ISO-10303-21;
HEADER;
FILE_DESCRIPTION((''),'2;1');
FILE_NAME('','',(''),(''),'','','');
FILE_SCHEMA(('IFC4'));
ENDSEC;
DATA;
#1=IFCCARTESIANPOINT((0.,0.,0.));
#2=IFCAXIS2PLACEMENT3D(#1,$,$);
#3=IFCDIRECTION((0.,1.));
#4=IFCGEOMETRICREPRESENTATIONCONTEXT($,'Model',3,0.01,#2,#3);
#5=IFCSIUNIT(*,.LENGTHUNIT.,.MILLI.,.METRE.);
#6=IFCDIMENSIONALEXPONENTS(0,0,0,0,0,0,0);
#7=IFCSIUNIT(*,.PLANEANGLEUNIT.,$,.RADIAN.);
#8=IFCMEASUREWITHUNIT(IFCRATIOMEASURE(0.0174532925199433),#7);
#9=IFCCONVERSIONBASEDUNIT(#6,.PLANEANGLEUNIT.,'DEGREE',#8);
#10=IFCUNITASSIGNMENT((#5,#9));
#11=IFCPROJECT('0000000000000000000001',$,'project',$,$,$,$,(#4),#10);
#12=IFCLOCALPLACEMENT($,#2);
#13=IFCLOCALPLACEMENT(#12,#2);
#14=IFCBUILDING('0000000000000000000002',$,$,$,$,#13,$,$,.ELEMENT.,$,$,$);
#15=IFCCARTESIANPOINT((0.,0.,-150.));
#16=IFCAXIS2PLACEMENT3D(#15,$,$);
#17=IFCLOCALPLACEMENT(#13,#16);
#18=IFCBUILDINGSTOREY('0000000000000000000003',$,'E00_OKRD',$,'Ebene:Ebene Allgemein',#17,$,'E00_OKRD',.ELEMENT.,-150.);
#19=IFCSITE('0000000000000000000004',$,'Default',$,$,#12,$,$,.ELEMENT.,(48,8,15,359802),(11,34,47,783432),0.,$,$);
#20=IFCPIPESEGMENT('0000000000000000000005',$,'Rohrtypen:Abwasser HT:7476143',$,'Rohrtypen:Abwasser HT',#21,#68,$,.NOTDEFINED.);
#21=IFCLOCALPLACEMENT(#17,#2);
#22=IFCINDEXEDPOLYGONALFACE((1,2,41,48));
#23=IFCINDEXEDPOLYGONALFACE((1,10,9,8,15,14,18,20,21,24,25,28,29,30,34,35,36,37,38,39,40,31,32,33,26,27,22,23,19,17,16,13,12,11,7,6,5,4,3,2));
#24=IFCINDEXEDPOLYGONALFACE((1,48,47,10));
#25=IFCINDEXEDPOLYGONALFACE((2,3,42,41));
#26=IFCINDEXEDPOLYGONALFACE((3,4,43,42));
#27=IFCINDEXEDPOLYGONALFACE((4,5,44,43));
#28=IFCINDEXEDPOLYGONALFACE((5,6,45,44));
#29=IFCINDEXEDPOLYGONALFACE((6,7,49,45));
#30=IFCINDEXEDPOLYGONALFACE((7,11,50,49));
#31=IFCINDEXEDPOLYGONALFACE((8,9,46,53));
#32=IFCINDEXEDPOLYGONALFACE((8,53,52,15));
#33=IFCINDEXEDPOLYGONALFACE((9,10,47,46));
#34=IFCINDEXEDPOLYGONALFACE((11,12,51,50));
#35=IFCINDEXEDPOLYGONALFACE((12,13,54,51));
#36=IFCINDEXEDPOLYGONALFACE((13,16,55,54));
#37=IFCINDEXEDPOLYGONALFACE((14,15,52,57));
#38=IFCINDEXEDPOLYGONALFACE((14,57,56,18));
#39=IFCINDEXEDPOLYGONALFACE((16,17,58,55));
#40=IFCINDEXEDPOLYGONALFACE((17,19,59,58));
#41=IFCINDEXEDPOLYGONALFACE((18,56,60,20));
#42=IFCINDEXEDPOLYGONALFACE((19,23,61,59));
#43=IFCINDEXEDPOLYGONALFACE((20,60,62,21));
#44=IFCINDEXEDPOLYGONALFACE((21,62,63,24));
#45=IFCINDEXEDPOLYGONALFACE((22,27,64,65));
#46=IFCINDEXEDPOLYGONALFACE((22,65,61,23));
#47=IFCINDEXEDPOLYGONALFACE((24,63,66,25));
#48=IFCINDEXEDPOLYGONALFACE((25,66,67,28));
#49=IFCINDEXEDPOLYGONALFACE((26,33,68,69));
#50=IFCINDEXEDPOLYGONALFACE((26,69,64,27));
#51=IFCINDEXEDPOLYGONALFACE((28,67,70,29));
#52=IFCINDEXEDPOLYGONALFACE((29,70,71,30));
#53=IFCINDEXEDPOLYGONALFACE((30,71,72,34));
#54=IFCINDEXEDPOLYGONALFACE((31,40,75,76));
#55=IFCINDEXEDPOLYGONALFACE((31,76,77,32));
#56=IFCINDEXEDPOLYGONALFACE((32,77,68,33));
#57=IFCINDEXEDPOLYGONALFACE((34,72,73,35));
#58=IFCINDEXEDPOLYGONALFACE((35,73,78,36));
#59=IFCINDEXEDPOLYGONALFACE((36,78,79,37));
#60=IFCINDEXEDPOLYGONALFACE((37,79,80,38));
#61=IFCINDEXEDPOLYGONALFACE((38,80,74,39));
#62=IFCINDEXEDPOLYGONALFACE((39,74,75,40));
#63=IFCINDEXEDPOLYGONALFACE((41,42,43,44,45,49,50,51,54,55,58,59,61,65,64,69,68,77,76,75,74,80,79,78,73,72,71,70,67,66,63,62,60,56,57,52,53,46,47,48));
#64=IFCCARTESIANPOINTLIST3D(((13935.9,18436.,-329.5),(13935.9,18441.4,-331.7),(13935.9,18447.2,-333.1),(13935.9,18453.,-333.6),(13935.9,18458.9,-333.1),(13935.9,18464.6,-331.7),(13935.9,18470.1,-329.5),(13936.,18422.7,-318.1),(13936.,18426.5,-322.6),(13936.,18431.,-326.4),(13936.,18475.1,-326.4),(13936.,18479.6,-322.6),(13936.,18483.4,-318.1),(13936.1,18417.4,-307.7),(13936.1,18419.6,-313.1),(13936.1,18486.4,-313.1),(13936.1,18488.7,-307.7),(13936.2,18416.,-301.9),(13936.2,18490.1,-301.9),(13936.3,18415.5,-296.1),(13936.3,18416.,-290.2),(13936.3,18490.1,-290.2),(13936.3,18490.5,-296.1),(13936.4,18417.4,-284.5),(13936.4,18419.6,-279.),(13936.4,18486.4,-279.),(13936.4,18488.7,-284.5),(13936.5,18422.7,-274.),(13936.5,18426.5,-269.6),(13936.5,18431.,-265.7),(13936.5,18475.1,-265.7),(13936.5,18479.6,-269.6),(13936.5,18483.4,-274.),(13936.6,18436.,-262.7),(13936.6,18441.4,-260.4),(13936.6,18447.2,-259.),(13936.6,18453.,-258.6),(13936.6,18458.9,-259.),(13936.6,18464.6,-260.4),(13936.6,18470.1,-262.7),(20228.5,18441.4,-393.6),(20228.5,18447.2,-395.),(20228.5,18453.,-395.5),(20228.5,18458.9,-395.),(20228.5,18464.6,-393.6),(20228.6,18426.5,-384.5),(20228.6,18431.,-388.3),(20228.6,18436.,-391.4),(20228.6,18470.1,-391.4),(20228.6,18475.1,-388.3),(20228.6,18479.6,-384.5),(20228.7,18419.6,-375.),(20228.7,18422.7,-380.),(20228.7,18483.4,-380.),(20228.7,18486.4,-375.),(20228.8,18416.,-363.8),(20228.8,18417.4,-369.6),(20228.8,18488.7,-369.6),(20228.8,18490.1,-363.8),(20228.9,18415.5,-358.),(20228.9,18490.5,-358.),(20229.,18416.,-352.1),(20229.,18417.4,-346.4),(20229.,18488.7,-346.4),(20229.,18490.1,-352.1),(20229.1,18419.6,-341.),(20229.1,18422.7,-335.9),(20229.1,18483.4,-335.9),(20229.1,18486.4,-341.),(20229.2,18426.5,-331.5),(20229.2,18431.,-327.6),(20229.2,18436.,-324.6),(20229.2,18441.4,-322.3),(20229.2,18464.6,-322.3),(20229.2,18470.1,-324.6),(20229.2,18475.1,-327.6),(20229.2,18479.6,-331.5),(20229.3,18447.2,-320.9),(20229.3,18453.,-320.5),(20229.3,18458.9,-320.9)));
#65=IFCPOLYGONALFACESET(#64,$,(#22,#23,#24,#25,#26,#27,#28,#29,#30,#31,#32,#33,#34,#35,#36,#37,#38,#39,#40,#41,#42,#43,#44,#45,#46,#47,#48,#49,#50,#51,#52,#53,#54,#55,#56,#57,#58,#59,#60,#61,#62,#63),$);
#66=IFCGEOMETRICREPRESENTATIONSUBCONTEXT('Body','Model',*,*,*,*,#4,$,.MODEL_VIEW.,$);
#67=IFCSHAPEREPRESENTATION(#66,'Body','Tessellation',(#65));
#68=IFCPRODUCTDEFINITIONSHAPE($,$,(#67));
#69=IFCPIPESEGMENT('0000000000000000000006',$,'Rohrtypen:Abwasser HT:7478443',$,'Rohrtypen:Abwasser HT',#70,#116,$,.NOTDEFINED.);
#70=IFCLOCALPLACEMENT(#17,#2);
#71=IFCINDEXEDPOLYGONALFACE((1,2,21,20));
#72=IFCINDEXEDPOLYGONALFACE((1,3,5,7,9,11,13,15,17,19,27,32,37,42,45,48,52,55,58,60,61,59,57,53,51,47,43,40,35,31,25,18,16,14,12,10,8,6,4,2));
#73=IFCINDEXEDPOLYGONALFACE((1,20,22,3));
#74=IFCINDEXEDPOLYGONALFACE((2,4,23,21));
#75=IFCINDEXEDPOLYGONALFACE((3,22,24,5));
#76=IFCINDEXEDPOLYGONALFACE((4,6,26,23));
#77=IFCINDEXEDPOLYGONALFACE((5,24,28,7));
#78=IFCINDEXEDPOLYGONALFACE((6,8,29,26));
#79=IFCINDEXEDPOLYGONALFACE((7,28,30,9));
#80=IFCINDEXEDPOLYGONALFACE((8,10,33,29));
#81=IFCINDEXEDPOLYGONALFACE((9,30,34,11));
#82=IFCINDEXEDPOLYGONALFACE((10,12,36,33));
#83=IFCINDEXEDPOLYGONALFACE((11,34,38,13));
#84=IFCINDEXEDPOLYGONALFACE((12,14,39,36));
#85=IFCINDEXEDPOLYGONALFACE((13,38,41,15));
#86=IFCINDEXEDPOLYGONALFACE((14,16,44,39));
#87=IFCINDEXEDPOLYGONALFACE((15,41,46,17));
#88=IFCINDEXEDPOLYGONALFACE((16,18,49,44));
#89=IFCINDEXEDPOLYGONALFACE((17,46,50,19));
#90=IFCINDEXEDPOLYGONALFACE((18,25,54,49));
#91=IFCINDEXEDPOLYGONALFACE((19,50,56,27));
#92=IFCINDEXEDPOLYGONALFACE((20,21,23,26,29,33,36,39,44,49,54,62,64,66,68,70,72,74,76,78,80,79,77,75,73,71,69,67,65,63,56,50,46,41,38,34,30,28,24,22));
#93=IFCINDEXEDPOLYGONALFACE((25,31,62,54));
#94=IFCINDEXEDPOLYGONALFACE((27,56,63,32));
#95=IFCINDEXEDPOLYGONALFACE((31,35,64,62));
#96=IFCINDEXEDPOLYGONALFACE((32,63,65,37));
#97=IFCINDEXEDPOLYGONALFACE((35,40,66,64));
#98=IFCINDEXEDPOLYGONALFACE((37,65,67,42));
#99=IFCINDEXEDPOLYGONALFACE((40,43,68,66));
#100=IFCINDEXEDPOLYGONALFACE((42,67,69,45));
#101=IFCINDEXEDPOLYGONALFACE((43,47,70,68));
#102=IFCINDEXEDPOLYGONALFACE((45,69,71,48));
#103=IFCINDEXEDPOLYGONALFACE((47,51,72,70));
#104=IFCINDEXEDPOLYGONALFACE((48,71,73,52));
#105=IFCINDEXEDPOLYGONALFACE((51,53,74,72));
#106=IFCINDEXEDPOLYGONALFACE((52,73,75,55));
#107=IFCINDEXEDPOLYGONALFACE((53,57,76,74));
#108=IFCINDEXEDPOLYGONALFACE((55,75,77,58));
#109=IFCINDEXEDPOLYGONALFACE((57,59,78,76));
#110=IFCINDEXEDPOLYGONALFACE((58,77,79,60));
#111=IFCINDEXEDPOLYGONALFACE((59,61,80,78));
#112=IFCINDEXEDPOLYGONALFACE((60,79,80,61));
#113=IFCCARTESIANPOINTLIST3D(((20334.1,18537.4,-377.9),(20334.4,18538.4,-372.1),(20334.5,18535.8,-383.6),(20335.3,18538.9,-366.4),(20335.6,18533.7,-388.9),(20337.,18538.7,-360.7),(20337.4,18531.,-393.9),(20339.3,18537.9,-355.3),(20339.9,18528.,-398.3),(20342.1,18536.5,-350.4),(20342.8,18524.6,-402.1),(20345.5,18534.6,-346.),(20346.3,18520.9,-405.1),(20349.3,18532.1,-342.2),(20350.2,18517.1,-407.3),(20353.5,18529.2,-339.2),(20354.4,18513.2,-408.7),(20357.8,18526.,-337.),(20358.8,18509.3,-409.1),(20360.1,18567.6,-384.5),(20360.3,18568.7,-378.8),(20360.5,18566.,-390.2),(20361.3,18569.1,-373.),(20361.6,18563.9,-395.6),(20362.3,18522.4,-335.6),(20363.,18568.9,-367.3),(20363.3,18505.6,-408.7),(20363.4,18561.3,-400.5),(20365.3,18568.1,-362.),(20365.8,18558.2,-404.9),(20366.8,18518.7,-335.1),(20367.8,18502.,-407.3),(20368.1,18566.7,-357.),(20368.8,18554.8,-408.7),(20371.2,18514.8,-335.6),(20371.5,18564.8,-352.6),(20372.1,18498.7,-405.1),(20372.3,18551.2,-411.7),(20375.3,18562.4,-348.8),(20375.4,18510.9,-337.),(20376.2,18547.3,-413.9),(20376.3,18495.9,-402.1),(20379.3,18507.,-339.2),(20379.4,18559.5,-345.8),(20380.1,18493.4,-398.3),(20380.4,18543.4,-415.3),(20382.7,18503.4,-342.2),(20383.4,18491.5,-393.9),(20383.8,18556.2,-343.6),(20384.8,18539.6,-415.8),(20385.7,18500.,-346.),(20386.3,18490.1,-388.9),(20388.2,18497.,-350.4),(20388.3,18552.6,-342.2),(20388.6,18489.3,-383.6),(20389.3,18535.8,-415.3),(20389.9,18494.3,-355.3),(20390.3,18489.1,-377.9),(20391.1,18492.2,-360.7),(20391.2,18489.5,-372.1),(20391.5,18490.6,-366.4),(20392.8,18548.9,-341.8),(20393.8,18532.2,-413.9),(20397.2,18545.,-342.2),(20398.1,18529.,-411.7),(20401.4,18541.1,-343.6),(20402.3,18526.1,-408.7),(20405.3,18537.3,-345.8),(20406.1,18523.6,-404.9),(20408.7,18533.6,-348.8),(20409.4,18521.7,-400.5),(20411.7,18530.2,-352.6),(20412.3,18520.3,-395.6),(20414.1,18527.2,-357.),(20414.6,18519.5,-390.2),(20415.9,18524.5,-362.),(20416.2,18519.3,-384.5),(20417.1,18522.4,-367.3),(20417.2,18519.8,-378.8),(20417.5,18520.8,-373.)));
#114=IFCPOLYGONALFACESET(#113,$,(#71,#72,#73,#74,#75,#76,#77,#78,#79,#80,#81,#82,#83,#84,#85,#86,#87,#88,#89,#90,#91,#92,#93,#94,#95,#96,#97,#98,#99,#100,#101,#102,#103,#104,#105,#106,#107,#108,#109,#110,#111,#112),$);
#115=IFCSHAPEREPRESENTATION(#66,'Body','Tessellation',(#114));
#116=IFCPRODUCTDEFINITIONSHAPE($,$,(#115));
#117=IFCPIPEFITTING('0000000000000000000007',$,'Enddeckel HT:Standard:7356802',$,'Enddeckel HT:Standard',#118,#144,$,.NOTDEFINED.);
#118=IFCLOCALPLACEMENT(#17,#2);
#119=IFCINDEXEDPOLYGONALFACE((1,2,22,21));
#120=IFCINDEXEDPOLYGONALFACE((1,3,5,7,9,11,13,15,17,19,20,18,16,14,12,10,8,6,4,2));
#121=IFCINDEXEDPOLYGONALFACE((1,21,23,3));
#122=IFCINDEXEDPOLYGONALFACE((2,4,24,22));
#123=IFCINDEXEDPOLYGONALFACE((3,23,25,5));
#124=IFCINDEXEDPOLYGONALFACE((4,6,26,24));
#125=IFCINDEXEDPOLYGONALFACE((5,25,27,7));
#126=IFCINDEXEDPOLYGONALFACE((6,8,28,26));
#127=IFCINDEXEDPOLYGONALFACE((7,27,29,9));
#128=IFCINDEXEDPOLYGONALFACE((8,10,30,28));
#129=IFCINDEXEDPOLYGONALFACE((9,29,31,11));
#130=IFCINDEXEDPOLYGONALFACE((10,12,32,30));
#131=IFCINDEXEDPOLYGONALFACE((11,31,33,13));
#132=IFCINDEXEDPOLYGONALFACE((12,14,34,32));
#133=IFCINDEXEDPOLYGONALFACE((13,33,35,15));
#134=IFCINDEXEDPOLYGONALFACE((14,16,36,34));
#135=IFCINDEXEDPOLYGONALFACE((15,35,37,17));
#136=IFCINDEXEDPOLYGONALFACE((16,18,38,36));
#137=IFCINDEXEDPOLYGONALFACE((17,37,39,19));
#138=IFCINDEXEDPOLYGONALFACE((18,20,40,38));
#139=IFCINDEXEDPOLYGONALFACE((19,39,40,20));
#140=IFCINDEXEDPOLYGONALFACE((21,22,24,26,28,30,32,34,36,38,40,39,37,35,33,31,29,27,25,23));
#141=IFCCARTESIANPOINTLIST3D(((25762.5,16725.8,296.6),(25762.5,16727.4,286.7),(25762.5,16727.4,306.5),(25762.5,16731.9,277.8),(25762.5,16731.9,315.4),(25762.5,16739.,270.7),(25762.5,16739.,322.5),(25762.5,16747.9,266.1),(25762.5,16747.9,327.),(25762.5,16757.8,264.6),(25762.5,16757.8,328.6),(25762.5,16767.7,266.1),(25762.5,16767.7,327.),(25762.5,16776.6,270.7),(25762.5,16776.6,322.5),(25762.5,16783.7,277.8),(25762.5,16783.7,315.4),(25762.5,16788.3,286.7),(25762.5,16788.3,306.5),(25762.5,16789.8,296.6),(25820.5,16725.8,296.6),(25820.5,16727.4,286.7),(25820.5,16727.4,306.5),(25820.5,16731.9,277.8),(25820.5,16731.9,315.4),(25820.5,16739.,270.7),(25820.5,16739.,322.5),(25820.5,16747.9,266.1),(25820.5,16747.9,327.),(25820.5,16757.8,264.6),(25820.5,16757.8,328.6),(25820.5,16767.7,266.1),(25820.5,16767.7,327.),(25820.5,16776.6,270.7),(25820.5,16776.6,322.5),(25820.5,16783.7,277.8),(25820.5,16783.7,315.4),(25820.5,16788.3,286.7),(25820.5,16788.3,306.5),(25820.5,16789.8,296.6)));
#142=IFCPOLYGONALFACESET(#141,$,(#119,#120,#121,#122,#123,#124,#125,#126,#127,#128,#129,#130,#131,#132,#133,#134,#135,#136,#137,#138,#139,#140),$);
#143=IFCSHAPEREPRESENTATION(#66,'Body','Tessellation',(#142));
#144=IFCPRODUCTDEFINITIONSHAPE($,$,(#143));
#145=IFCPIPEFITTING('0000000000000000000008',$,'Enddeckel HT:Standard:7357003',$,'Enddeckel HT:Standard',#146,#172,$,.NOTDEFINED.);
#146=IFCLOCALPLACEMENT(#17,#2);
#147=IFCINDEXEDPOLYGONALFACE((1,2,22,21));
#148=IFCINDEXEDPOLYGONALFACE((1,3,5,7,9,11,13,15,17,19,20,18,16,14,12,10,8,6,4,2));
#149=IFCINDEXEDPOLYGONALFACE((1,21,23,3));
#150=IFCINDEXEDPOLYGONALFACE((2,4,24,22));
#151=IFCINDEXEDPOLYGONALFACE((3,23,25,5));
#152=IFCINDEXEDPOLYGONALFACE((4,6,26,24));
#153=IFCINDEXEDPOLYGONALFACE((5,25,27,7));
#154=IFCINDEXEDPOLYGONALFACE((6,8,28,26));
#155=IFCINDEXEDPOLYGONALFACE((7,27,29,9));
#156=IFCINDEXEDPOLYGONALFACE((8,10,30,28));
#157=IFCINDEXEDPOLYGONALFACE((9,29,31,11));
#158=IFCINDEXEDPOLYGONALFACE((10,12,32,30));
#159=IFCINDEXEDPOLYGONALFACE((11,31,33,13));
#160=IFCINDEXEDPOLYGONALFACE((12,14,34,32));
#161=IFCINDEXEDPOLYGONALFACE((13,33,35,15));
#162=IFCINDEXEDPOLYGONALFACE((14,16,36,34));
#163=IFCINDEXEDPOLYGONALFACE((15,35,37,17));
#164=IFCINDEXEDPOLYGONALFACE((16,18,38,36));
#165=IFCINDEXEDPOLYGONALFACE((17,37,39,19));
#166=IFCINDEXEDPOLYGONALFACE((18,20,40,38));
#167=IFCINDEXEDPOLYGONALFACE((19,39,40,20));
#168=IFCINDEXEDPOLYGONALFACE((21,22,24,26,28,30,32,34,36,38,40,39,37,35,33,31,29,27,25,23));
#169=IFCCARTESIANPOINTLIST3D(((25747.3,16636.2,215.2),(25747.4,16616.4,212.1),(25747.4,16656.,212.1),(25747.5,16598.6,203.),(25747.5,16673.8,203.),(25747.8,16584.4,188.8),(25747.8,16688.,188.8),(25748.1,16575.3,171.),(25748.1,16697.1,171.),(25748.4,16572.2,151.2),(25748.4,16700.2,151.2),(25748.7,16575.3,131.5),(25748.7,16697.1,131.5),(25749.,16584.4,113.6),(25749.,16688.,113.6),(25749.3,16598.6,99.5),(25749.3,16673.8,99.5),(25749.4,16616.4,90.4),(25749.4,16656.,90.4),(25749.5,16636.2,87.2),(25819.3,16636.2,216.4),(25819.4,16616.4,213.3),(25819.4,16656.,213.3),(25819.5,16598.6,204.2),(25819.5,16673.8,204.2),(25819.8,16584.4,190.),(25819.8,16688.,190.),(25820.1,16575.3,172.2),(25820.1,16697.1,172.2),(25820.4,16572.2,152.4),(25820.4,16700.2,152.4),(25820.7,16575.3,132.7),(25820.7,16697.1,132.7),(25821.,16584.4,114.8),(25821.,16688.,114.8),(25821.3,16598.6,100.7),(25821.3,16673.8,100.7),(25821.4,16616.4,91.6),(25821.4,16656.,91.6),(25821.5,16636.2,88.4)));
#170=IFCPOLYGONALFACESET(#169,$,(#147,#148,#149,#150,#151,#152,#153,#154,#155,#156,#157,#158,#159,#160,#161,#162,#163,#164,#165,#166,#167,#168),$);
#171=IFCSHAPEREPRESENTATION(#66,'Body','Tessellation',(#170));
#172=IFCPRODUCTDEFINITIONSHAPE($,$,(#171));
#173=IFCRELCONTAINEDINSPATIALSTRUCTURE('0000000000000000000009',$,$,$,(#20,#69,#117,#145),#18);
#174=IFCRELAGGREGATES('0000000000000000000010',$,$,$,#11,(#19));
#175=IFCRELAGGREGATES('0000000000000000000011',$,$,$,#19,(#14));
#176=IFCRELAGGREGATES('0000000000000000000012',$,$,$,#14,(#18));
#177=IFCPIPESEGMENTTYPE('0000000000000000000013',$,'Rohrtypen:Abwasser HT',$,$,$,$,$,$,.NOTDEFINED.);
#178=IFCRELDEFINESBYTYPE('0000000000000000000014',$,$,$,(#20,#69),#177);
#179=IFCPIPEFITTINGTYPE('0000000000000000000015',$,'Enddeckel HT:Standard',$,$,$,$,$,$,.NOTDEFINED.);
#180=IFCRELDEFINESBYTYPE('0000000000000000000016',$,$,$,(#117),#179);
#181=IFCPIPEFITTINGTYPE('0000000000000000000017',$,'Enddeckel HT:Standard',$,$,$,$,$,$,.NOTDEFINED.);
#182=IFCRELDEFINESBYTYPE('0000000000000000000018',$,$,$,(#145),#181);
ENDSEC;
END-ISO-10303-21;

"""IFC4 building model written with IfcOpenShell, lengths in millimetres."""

from ifc_helpers import new_model, entity, si_unit, converted_unit, direction, frame, origin, place, context, subcontext, project, spatial, indexed_curve, outline, extrude, source, transform, mapped, type_object, type_shapes, element, save


model = new_model("IFC4")

# Units and contexts
model_context = context("Model", 3, precision=0.01, world=origin(), true_north=direction((0.0, 1.0)))
body_context = subcontext(model_context, "Body", "Model", "MODEL_VIEW")
ifc_project = project(units=[si_unit("LENGTHUNIT", "METRE", prefix="MILLI"), converted_unit("PLANEANGLEUNIT", "DEGREE", entity("IfcRatioMeasure", 0.0174532925199433), si_unit("PLANEANGLEUNIT", "RADIAN"), dimensions=[0, 0, 0, 0, 0, 0, 0])], contexts=[model_context])

# Site, building, storey
site_placement = place(None, origin())
site = spatial("IfcSite", under=ifc_project, at=site_placement, Name="Default", CompositionType="ELEMENT", RefLatitude=(48, 8, 15, 359802), RefLongitude=(11, 34, 47, 783432), RefElevation=0.0)
building_placement = place(site_placement, origin())
building = spatial("IfcBuilding", under=site, at=building_placement, CompositionType="ELEMENT")
storey_placement = place(building_placement, frame((0.0, 0.0, -150.0)))
storey = spatial("IfcBuildingStorey", under=building, at=storey_placement, Name="E00_OKRD", ObjectType="Ebene:Ebene Allgemein", LongName="E00_OKRD", CompositionType="ELEMENT", Elevation=-150.0)

# Pipe segments
pipe_segment_type_1 = type_object("IfcPipeSegmentType", Name="Rohrtypen:Abwasser HT", PredefinedType="NOTDEFINED")
pipe_segment_1_placement = place(storey_placement, origin())
element("IfcPipeSegment", 1, at=pipe_segment_1_placement, inside=storey, type_object=pipe_segment_type_1, Name="Rohrtypen:Abwasser HT:7476143", ObjectType="Rohrtypen:Abwasser HT", PredefinedType="NOTDEFINED", context=body_context, shape_type="SweptSolid", body=[
    extrude(outline(indexed_curve([(37.5, 0.0), (37.0, 5.9), (35.7, 11.6), (33.4, 17.0), (30.3, 22.0), (26.5, 26.5), (22.0, 30.3), (17.0, 33.4), (11.6, 35.7), (5.9, 37.0), (0.0, 37.5), (-5.9, 37.0), (-11.6, 35.7), (-17.0, 33.4), (-22.0, 30.3), (-26.5, 26.5), (-30.3, 22.0), (-33.4, 17.0), (-35.7, 11.6), (-37.0, 5.9), (-37.5, 0.0), (-37.0, -5.9), (-35.7, -11.6), (-33.4, -17.0), (-30.3, -22.0), (-26.5, -26.5), (-22.0, -30.3), (-17.0, -33.4), (-11.6, -35.7), (-5.9, -37.0), (0.0, -37.5), (5.9, -37.0), (11.6, -35.7), (17.0, -33.4), (22.0, -30.3), (26.5, -26.5), (30.3, -22.0), (33.4, -17.0), (35.7, -11.6), (37.0, -5.9), (37.5, 0.0)], self_intersect=False)), frame((13936.3, 18453.0, -296.1), z_axis=(0.999952, 0.0, -0.009839), x_axis=(0.0, -1.0, 0.0)), (0.0, 0.0, 1.0), 6292.9),
])
pipe_segment_2_placement = place(storey_placement, origin())
element("IfcPipeSegment", 2, at=pipe_segment_2_placement, inside=storey, type_object=pipe_segment_type_1, Name="Rohrtypen:Abwasser HT:7478443", ObjectType="Rohrtypen:Abwasser HT", PredefinedType="NOTDEFINED", context=body_context, shape_type="SweptSolid", body=[
    extrude(outline(indexed_curve([(37.5, 0.0), (37.0, 5.9), (35.7, 11.6), (33.4, 17.0), (30.3, 22.0), (26.5, 26.5), (22.0, 30.3), (17.0, 33.4), (11.6, 35.7), (5.9, 37.0), (0.0, 37.5), (-5.9, 37.0), (-11.6, 35.7), (-17.0, 33.4), (-22.0, 30.3), (-26.5, 26.5), (-30.3, 22.0), (-33.4, 17.0), (-35.7, 11.6), (-37.0, 5.9), (-37.5, 0.0), (-37.0, -5.9), (-35.7, -11.6), (-33.4, -17.0), (-30.3, -22.0), (-26.5, -26.5), (-22.0, -30.3), (-17.0, -33.4), (-11.6, -35.7), (-5.9, -37.0), (0.0, -37.5), (5.9, -37.0), (11.6, -35.7), (17.0, -33.4), (22.0, -30.3), (26.5, -26.5), (30.3, -22.0), (33.4, -17.0), (35.7, -11.6), (37.0, -5.9), (37.5, 0.0)], self_intersect=False)), frame((20388.8, 18544.2, -378.8), z_axis=(-0.643131, -0.74801, 0.163901), x_axis=(0.758265, -0.651947, 0.0)), (0.0, 0.0, 1.0), 40.4),
])

# Pipe fittings
pipe_fitting_type_1 = type_object("IfcPipeFittingType", Name="Enddeckel HT:Standard", PredefinedType="NOTDEFINED")
shared_shape_1 = source(origin(), body_context, "Body", "SweptSolid", [
    extrude(outline(indexed_curve([(32.0, 0.0), (30.4, 9.9), (25.9, 18.8), (18.8, 25.9), (9.9, 30.4), (0.0, 32.0), (-9.9, 30.4), (-18.8, 25.9), (-25.9, 18.8), (-30.4, 9.9), (-32.0, 0.0), (-30.4, -9.9), (-25.9, -18.8), (-18.8, -25.9), (-9.9, -30.4), (0.0, -32.0), (9.9, -30.4), (18.8, -25.9), (25.9, -18.8), (30.4, -9.9), (32.0, 0.0)], self_intersect=False)), frame((0.0, 0.0, 0.0), z_axis=(1.0, 0.0, 0.0), x_axis=(0.0, 1.0, 0.0)), (0.0, 0.0, 1.0), 58.0),
])
type_shapes(pipe_fitting_type_1, [shared_shape_1])
pipe_fitting_1_placement = place(storey_placement, frame((25762.5, 16757.8, 296.6)))
element("IfcPipeFitting", 3, at=pipe_fitting_1_placement, inside=storey, type_object=pipe_fitting_type_1, Name="Enddeckel HT:Standard:7356802", ObjectType="Enddeckel HT:Standard", PredefinedType="NOTDEFINED", context=body_context, shape_type="MappedRepresentation", body=[
    mapped(shared_shape_1, transform((0.0, 0.0, 0.0), scale=1.0)),
])
pipe_fitting_type_2 = type_object("IfcPipeFittingType", Name="Enddeckel HT:Standard", PredefinedType="NOTDEFINED")
shared_shape_2 = source(origin(), body_context, "Body", "SweptSolid", [
    extrude(outline(indexed_curve([(64.0, 0.0), (60.9, 19.8), (51.8, 37.6), (37.6, 51.8), (19.8, 60.9), (0.0, 64.0), (-19.8, 60.9), (-37.6, 51.8), (-51.8, 37.6), (-60.9, 19.8), (-64.0, 0.0), (-60.9, -19.8), (-51.8, -37.6), (-37.6, -51.8), (-19.8, -60.9), (0.0, -64.0), (19.8, -60.9), (37.6, -51.8), (51.8, -37.6), (60.9, -19.8), (64.0, 0.0)], self_intersect=False)), frame((0.0, 0.0, 0.0), z_axis=(1.0, 0.0, 0.0), x_axis=(0.0, 1.0, 0.0)), (0.0, 0.0, 1.0), 72.0),
])
type_shapes(pipe_fitting_type_2, [shared_shape_2])
for number, where, z_axis, x_axis, name in (
    (4, (25748.4, 16636.2, 151.2), (-0.016604, 0.0, 0.999862), (0.999862, 0.0, 0.016604), "Enddeckel HT:Standard:7357003"),
):
    element("IfcPipeFitting", number, at=place(storey_placement, frame(where, z_axis=z_axis, x_axis=x_axis)), inside=storey, type_object=pipe_fitting_type_2, Name=name, ObjectType="Enddeckel HT:Standard", PredefinedType="NOTDEFINED", context=body_context, shape_type="MappedRepresentation", body=[
        mapped(shared_shape_2, transform((0.0, 0.0, 0.0), scale=1.0)),
    ])

save(model, "model.ifc")
